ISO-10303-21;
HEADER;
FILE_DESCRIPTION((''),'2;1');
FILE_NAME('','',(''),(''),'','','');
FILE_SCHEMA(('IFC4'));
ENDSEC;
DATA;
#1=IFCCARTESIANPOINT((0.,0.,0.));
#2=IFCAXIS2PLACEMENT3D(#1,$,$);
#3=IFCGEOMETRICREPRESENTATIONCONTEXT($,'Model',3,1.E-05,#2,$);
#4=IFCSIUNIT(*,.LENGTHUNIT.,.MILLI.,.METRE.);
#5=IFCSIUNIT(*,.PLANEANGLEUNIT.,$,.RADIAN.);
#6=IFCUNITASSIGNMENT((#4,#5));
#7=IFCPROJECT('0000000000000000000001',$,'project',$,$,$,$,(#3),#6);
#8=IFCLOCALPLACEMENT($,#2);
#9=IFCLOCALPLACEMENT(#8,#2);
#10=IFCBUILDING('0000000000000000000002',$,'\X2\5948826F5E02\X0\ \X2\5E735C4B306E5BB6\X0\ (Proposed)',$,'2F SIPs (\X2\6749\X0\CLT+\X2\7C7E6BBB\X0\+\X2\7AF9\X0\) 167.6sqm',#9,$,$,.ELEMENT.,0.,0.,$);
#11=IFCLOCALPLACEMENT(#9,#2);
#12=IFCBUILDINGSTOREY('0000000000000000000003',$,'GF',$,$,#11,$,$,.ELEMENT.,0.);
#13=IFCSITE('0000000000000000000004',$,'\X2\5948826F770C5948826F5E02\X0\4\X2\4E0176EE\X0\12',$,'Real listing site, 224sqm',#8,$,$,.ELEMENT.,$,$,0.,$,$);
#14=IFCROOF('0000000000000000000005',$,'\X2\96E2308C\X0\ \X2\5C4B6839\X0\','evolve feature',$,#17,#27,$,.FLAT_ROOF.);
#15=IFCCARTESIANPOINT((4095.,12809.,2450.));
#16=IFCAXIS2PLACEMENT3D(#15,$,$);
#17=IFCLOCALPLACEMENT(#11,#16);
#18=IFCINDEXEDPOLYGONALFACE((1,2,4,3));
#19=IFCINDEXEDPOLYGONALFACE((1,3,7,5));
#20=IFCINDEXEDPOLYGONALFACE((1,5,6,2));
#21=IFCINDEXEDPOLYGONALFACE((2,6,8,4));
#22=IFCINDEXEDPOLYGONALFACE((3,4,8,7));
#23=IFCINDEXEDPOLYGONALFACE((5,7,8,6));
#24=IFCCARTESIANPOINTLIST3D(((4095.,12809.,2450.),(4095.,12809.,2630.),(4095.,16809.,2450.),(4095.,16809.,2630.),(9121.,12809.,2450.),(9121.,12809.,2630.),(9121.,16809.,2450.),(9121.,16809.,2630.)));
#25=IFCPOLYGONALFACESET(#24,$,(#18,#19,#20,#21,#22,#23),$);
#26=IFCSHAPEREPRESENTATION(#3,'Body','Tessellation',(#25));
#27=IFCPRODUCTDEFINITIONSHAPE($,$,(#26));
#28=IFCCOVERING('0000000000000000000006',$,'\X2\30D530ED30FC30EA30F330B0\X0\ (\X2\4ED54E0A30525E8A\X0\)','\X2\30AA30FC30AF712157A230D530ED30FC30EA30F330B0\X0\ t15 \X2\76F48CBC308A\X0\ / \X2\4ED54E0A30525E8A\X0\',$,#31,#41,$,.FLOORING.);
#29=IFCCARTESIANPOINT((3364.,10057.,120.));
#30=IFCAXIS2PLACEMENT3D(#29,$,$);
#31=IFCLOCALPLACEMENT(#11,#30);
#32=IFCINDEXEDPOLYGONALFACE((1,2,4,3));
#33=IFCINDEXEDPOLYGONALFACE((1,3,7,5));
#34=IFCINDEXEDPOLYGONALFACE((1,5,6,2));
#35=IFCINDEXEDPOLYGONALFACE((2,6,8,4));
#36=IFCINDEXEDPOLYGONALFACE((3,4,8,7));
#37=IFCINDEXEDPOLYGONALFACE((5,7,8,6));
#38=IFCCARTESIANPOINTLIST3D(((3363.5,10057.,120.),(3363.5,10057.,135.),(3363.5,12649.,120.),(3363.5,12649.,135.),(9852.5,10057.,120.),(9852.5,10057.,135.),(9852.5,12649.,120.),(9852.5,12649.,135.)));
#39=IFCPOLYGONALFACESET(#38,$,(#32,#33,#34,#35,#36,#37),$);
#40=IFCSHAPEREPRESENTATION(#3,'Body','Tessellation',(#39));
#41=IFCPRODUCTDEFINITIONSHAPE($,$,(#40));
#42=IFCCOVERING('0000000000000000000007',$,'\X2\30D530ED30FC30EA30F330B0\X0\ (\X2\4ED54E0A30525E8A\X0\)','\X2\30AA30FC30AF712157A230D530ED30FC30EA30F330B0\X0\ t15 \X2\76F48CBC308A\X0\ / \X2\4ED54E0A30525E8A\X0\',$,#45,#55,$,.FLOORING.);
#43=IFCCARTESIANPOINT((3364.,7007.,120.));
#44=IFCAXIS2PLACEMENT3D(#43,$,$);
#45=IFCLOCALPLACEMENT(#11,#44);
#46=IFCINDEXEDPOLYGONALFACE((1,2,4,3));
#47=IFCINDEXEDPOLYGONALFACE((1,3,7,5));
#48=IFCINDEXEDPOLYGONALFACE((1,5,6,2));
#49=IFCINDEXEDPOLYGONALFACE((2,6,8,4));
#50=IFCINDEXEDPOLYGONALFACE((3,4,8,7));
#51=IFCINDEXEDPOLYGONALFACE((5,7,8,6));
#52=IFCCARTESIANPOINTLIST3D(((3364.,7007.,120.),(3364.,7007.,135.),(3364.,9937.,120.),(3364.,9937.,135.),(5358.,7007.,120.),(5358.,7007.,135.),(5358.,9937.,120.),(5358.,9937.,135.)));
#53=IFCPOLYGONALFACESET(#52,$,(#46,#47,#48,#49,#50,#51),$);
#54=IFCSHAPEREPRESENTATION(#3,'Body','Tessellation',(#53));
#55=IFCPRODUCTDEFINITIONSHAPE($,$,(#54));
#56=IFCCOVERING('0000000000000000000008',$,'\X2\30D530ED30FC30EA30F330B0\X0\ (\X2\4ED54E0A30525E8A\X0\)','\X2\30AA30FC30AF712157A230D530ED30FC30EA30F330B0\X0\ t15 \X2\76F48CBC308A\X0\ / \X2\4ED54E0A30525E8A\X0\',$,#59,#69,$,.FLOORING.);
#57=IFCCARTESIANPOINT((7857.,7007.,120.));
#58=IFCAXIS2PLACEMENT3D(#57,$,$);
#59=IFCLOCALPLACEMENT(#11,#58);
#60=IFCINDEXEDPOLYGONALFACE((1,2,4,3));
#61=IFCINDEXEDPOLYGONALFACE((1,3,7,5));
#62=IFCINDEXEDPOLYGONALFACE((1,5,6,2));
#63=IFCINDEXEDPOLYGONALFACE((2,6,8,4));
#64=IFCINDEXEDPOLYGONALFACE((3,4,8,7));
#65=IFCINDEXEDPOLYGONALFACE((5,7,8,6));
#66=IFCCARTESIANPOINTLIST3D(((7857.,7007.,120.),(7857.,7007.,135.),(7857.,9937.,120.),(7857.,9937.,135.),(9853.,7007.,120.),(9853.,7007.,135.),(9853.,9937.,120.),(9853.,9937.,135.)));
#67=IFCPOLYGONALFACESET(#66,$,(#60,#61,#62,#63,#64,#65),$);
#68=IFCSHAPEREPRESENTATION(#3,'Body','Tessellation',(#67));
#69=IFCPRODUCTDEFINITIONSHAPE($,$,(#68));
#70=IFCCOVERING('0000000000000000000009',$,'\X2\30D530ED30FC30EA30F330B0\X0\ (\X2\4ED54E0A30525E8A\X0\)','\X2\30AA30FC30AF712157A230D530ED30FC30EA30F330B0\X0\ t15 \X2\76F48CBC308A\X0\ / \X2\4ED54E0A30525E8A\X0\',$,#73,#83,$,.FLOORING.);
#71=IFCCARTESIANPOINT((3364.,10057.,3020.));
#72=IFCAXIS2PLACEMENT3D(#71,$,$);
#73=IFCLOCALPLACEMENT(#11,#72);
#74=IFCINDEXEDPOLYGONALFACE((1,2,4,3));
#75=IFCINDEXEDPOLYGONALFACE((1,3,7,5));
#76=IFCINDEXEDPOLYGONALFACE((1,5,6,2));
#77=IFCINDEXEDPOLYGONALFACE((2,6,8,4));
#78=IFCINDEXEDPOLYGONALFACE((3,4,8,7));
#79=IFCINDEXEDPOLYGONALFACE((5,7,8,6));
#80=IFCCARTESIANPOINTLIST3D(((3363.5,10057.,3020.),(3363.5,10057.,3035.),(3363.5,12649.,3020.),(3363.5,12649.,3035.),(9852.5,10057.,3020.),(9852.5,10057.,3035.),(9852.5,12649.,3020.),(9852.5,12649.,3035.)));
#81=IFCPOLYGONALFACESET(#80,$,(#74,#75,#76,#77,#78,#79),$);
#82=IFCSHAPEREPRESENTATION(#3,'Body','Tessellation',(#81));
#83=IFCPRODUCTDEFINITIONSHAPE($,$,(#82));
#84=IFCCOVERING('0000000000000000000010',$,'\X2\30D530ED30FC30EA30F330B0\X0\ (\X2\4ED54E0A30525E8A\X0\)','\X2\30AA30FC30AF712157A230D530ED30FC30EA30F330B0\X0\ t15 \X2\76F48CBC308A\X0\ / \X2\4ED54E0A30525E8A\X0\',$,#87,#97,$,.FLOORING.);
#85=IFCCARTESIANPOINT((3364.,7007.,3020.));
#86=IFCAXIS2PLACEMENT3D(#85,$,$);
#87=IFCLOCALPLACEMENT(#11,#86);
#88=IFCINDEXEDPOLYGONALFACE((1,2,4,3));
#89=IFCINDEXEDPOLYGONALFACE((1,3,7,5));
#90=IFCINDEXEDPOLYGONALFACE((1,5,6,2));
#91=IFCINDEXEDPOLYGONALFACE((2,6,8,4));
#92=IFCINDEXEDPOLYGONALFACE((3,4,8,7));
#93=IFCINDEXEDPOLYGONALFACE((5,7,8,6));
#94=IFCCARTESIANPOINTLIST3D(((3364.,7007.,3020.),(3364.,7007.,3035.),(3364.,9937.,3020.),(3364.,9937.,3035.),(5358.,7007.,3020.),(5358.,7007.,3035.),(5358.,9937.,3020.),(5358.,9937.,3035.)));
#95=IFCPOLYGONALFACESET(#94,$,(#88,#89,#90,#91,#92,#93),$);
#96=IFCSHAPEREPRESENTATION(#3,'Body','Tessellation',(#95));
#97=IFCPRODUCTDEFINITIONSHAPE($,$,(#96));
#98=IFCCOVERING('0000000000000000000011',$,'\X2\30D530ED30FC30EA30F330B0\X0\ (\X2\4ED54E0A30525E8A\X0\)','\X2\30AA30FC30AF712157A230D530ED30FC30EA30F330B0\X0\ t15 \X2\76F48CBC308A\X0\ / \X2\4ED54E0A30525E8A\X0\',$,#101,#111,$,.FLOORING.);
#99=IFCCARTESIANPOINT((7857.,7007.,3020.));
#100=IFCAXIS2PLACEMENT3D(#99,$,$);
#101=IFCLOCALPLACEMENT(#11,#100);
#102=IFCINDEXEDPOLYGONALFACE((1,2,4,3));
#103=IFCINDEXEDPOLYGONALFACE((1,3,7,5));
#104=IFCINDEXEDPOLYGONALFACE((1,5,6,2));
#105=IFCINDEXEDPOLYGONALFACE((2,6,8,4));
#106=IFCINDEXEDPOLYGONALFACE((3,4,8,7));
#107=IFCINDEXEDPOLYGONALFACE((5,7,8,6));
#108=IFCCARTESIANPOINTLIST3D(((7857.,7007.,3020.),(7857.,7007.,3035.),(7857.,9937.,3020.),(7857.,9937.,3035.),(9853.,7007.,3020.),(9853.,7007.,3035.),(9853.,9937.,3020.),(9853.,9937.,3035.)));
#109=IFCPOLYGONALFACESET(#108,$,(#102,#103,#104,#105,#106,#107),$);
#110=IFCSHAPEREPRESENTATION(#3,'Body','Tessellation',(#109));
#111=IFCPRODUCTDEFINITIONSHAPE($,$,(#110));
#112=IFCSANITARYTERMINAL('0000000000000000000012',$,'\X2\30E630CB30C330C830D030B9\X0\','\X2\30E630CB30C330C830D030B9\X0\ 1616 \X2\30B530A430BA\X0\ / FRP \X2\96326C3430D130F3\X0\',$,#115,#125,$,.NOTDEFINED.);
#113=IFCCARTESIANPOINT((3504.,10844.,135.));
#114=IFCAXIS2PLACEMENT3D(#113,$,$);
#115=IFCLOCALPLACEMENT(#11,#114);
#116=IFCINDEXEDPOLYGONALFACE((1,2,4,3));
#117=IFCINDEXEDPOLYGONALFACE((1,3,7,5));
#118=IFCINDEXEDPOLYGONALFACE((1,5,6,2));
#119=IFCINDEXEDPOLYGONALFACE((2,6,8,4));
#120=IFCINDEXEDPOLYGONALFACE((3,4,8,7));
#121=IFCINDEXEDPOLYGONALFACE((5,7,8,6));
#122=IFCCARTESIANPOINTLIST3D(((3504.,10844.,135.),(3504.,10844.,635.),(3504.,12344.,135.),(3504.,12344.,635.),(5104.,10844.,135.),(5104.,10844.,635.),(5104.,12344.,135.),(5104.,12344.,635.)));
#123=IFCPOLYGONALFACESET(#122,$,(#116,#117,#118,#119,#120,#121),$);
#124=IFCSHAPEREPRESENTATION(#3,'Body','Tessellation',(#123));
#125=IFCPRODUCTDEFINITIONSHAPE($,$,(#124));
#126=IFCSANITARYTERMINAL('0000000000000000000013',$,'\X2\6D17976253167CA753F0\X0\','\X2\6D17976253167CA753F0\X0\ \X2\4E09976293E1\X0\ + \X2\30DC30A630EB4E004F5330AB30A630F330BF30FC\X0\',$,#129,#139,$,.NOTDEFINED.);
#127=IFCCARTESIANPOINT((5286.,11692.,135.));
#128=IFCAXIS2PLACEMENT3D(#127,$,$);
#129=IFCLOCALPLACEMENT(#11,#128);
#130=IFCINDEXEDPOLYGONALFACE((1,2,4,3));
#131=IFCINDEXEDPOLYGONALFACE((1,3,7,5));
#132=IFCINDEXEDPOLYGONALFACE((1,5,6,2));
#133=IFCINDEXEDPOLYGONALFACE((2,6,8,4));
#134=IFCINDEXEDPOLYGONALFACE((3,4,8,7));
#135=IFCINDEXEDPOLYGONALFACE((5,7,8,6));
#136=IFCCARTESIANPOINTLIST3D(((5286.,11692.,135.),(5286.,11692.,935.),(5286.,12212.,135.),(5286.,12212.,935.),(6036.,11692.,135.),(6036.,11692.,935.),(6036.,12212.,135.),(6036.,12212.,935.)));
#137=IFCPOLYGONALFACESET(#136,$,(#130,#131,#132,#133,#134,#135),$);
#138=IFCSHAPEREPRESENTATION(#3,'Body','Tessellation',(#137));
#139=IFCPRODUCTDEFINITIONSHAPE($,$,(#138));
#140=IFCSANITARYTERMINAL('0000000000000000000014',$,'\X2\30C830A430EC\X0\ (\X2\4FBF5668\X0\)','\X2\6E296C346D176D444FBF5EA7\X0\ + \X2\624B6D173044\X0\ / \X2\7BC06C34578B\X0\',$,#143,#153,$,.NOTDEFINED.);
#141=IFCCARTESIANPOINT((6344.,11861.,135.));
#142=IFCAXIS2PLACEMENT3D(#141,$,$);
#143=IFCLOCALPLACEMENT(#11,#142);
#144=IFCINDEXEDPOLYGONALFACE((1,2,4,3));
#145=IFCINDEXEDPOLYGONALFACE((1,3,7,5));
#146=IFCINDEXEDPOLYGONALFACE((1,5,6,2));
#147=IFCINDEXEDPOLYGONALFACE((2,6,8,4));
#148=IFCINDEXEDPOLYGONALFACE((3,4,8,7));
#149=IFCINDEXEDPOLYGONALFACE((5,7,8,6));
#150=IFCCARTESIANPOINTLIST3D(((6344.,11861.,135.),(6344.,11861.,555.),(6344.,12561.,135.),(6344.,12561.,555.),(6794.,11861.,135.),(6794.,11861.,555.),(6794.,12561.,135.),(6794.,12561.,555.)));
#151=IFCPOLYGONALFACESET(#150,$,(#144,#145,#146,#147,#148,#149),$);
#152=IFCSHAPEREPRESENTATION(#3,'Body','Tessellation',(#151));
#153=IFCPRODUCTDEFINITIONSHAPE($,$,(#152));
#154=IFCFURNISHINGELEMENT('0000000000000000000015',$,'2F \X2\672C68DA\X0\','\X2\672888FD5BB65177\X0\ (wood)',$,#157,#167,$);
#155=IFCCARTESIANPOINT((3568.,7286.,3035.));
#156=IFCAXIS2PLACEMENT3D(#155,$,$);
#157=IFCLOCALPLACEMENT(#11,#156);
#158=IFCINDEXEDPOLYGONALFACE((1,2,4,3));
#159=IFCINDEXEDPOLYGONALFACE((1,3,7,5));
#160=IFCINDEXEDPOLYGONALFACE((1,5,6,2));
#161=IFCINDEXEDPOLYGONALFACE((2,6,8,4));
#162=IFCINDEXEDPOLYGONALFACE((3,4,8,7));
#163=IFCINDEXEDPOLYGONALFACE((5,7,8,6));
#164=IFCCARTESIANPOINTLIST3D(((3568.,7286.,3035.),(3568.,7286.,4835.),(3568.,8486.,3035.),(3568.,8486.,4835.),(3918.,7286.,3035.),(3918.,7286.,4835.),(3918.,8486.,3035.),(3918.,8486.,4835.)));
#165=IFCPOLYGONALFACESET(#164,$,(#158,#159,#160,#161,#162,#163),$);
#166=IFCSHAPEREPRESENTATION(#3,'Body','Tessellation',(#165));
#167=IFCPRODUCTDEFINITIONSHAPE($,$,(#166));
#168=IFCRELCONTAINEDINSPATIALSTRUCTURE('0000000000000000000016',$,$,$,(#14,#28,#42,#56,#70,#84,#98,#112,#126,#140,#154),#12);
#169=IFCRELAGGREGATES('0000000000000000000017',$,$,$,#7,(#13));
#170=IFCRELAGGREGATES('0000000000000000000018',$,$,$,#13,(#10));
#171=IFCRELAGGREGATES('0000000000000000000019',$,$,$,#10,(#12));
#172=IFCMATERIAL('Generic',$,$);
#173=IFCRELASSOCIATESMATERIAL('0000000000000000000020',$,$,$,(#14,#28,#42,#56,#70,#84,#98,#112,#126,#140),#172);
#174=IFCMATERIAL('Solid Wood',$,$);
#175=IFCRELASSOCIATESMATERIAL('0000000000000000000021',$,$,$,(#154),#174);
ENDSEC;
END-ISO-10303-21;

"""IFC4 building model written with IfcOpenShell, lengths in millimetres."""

from ifc_helpers import new_model, si_unit, frame, frame_2d, origin, place, context, project, spatial, rectangle, extrude, material, element, save


model = new_model("IFC4")

# Units and contexts
model_context = context("Model", 3, precision=1e-05, world=origin())
ifc_project = project(units=[si_unit("LENGTHUNIT", "METRE", prefix="MILLI"), si_unit("PLANEANGLEUNIT", "RADIAN")], contexts=[model_context])

# Site, building, storey
site_placement = place(None, origin())
site = spatial("IfcSite", under=ifc_project, at=site_placement, Name="奈良県奈良市4丁目12", ObjectType="Real listing site, 224sqm", CompositionType="ELEMENT", RefElevation=0.0)
building_placement = place(site_placement, origin())
building = spatial("IfcBuilding", under=site, at=building_placement, Name="奈良市 平屋の家 (Proposed)", ObjectType="2F SIPs (杉CLT+籾殻+竹) 167.6sqm", CompositionType="ELEMENT", ElevationOfRefHeight=0.0, ElevationOfTerrain=0.0)
storey_placement = place(building_placement, origin())
storey = spatial("IfcBuildingStorey", under=building, at=storey_placement, Name="GF", CompositionType="ELEMENT", Elevation=0.0)

# Shared definitions
ifc_material_1 = material(Name="Solid Wood")
ifc_material_2 = material(Name="Generic")

# Roof
roof_1_placement = place(storey_placement, frame((4095.0, 12809.0, 2450.0)))
element("IfcRoof", 1, at=roof_1_placement, inside=storey, material=ifc_material_2, Name="離れ 屋根", Description="evolve feature", PredefinedType="FLAT_ROOF", context=model_context, shape_type="SweptSolid", body=[
    extrude(rectangle(XDim=5026.0, YDim=4000.0, at=frame_2d((2513.0, 2000.0))), frame((4095.0, 12809.0, 2450.0)), (0.0, 0.0, 1.0), 180.0),
])

# Coverings
covering_1_placement = place(storey_placement, frame((3364.0, 10057.0, 120.0)))
element("IfcCovering", 2, at=covering_1_placement, inside=storey, material=ifc_material_2, Name="フローリング (仕上げ床)", Description="オーク無垢フローリング t15 直貼り / 仕上げ床", PredefinedType="FLOORING", context=model_context, shape_type="SweptSolid", body=[
    extrude(rectangle(XDim=6489.0, YDim=2592.0, at=frame_2d((3244.0, 1296.0))), frame((3364.0, 10057.0, 120.0)), (0.0, 0.0, 1.0), 15.0),
])
covering_2_placement = place(storey_placement, frame((3364.0, 7007.0, 120.0)))
element("IfcCovering", 3, at=covering_2_placement, inside=storey, material=ifc_material_2, Name="フローリング (仕上げ床)", Description="オーク無垢フローリング t15 直貼り / 仕上げ床", PredefinedType="FLOORING", context=model_context, shape_type="SweptSolid", body=[
    extrude(rectangle(XDim=1994.0, YDim=2930.0, at=frame_2d((997.0, 1465.0))), frame((3364.0, 7007.0, 120.0)), (0.0, 0.0, 1.0), 15.0),
])
covering_3_placement = place(storey_placement, frame((7857.0, 7007.0, 120.0)))
element("IfcCovering", 4, at=covering_3_placement, inside=storey, material=ifc_material_2, Name="フローリング (仕上げ床)", Description="オーク無垢フローリング t15 直貼り / 仕上げ床", PredefinedType="FLOORING", context=model_context, shape_type="SweptSolid", body=[
    extrude(rectangle(XDim=1996.0, YDim=2930.0, at=frame_2d((998.0, 1465.0))), frame((7857.0, 7007.0, 120.0)), (0.0, 0.0, 1.0), 15.0),
])
covering_4_placement = place(storey_placement, frame((3364.0, 10057.0, 3020.0)))
element("IfcCovering", 5, at=covering_4_placement, inside=storey, material=ifc_material_2, Name="フローリング (仕上げ床)", Description="オーク無垢フローリング t15 直貼り / 仕上げ床", PredefinedType="FLOORING", context=model_context, shape_type="SweptSolid", body=[
    extrude(rectangle(XDim=6489.0, YDim=2592.0, at=frame_2d((3244.0, 1296.0))), frame((3364.0, 10057.0, 3020.0)), (0.0, 0.0, 1.0), 15.0),
])
covering_5_placement = place(storey_placement, frame((3364.0, 7007.0, 3020.0)))
element("IfcCovering", 6, at=covering_5_placement, inside=storey, material=ifc_material_2, Name="フローリング (仕上げ床)", Description="オーク無垢フローリング t15 直貼り / 仕上げ床", PredefinedType="FLOORING", context=model_context, shape_type="SweptSolid", body=[
    extrude(rectangle(XDim=1994.0, YDim=2930.0, at=frame_2d((997.0, 1465.0))), frame((3364.0, 7007.0, 3020.0)), (0.0, 0.0, 1.0), 15.0),
])
covering_6_placement = place(storey_placement, frame((7857.0, 7007.0, 3020.0)))
element("IfcCovering", 7, at=covering_6_placement, inside=storey, material=ifc_material_2, Name="フローリング (仕上げ床)", Description="オーク無垢フローリング t15 直貼り / 仕上げ床", PredefinedType="FLOORING", context=model_context, shape_type="SweptSolid", body=[
    extrude(rectangle(XDim=1996.0, YDim=2930.0, at=frame_2d((998.0, 1465.0))), frame((7857.0, 7007.0, 3020.0)), (0.0, 0.0, 1.0), 15.0),
])

# Sanitary terminals
sanitary_terminal_1_placement = place(storey_placement, frame((3504.0, 10844.0, 135.0)))
element("IfcSanitaryTerminal", 8, at=sanitary_terminal_1_placement, inside=storey, material=ifc_material_2, Name="ユニットバス", Description="ユニットバス 1616 サイズ / FRP 防水パン", PredefinedType="NOTDEFINED", context=model_context, shape_type="SweptSolid", body=[
    extrude(rectangle(XDim=1600.0, YDim=1500.0, at=frame_2d((800.0, 750.0))), frame((3504.0, 10844.0, 135.0)), (0.0, 0.0, 1.0), 500.0),
])
sanitary_terminal_2_placement = place(storey_placement, frame((5286.0, 11692.0, 135.0)))
element("IfcSanitaryTerminal", 9, at=sanitary_terminal_2_placement, inside=storey, material=ifc_material_2, Name="洗面化粧台", Description="洗面化粧台 三面鏡 + ボウル一体カウンター", PredefinedType="NOTDEFINED", context=model_context, shape_type="SweptSolid", body=[
    extrude(rectangle(XDim=750.0, YDim=520.0, at=frame_2d((375.0, 260.0))), frame((5286.0, 11692.0, 135.0)), (0.0, 0.0, 1.0), 800.0),
])
sanitary_terminal_3_placement = place(storey_placement, frame((6344.0, 11861.0, 135.0)))
element("IfcSanitaryTerminal", 10, at=sanitary_terminal_3_placement, inside=storey, material=ifc_material_2, Name="トイレ (便器)", Description="温水洗浄便座 + 手洗い / 節水型", PredefinedType="NOTDEFINED", context=model_context, shape_type="SweptSolid", body=[
    extrude(rectangle(XDim=450.0, YDim=700.0, at=frame_2d((225.0, 350.0))), frame((6344.0, 11861.0, 135.0)), (0.0, 0.0, 1.0), 420.0),
])

# Furnishing element
furnishing_placement = place(storey_placement, frame((3568.0, 7286.0, 3035.0)))
element("IfcFurnishingElement", 11, at=furnishing_placement, inside=storey, material=ifc_material_1, Name="2F 本棚", Description="木製家具 (wood)", context=model_context, shape_type="SweptSolid", body=[
    extrude(rectangle(XDim=350.0, YDim=1200.0, at=frame_2d((175.0, 600.0))), frame((3568.0, 7286.0, 3035.0)), (0.0, 0.0, 1.0), 1800.0),
])

save(model, "model.ifc")
